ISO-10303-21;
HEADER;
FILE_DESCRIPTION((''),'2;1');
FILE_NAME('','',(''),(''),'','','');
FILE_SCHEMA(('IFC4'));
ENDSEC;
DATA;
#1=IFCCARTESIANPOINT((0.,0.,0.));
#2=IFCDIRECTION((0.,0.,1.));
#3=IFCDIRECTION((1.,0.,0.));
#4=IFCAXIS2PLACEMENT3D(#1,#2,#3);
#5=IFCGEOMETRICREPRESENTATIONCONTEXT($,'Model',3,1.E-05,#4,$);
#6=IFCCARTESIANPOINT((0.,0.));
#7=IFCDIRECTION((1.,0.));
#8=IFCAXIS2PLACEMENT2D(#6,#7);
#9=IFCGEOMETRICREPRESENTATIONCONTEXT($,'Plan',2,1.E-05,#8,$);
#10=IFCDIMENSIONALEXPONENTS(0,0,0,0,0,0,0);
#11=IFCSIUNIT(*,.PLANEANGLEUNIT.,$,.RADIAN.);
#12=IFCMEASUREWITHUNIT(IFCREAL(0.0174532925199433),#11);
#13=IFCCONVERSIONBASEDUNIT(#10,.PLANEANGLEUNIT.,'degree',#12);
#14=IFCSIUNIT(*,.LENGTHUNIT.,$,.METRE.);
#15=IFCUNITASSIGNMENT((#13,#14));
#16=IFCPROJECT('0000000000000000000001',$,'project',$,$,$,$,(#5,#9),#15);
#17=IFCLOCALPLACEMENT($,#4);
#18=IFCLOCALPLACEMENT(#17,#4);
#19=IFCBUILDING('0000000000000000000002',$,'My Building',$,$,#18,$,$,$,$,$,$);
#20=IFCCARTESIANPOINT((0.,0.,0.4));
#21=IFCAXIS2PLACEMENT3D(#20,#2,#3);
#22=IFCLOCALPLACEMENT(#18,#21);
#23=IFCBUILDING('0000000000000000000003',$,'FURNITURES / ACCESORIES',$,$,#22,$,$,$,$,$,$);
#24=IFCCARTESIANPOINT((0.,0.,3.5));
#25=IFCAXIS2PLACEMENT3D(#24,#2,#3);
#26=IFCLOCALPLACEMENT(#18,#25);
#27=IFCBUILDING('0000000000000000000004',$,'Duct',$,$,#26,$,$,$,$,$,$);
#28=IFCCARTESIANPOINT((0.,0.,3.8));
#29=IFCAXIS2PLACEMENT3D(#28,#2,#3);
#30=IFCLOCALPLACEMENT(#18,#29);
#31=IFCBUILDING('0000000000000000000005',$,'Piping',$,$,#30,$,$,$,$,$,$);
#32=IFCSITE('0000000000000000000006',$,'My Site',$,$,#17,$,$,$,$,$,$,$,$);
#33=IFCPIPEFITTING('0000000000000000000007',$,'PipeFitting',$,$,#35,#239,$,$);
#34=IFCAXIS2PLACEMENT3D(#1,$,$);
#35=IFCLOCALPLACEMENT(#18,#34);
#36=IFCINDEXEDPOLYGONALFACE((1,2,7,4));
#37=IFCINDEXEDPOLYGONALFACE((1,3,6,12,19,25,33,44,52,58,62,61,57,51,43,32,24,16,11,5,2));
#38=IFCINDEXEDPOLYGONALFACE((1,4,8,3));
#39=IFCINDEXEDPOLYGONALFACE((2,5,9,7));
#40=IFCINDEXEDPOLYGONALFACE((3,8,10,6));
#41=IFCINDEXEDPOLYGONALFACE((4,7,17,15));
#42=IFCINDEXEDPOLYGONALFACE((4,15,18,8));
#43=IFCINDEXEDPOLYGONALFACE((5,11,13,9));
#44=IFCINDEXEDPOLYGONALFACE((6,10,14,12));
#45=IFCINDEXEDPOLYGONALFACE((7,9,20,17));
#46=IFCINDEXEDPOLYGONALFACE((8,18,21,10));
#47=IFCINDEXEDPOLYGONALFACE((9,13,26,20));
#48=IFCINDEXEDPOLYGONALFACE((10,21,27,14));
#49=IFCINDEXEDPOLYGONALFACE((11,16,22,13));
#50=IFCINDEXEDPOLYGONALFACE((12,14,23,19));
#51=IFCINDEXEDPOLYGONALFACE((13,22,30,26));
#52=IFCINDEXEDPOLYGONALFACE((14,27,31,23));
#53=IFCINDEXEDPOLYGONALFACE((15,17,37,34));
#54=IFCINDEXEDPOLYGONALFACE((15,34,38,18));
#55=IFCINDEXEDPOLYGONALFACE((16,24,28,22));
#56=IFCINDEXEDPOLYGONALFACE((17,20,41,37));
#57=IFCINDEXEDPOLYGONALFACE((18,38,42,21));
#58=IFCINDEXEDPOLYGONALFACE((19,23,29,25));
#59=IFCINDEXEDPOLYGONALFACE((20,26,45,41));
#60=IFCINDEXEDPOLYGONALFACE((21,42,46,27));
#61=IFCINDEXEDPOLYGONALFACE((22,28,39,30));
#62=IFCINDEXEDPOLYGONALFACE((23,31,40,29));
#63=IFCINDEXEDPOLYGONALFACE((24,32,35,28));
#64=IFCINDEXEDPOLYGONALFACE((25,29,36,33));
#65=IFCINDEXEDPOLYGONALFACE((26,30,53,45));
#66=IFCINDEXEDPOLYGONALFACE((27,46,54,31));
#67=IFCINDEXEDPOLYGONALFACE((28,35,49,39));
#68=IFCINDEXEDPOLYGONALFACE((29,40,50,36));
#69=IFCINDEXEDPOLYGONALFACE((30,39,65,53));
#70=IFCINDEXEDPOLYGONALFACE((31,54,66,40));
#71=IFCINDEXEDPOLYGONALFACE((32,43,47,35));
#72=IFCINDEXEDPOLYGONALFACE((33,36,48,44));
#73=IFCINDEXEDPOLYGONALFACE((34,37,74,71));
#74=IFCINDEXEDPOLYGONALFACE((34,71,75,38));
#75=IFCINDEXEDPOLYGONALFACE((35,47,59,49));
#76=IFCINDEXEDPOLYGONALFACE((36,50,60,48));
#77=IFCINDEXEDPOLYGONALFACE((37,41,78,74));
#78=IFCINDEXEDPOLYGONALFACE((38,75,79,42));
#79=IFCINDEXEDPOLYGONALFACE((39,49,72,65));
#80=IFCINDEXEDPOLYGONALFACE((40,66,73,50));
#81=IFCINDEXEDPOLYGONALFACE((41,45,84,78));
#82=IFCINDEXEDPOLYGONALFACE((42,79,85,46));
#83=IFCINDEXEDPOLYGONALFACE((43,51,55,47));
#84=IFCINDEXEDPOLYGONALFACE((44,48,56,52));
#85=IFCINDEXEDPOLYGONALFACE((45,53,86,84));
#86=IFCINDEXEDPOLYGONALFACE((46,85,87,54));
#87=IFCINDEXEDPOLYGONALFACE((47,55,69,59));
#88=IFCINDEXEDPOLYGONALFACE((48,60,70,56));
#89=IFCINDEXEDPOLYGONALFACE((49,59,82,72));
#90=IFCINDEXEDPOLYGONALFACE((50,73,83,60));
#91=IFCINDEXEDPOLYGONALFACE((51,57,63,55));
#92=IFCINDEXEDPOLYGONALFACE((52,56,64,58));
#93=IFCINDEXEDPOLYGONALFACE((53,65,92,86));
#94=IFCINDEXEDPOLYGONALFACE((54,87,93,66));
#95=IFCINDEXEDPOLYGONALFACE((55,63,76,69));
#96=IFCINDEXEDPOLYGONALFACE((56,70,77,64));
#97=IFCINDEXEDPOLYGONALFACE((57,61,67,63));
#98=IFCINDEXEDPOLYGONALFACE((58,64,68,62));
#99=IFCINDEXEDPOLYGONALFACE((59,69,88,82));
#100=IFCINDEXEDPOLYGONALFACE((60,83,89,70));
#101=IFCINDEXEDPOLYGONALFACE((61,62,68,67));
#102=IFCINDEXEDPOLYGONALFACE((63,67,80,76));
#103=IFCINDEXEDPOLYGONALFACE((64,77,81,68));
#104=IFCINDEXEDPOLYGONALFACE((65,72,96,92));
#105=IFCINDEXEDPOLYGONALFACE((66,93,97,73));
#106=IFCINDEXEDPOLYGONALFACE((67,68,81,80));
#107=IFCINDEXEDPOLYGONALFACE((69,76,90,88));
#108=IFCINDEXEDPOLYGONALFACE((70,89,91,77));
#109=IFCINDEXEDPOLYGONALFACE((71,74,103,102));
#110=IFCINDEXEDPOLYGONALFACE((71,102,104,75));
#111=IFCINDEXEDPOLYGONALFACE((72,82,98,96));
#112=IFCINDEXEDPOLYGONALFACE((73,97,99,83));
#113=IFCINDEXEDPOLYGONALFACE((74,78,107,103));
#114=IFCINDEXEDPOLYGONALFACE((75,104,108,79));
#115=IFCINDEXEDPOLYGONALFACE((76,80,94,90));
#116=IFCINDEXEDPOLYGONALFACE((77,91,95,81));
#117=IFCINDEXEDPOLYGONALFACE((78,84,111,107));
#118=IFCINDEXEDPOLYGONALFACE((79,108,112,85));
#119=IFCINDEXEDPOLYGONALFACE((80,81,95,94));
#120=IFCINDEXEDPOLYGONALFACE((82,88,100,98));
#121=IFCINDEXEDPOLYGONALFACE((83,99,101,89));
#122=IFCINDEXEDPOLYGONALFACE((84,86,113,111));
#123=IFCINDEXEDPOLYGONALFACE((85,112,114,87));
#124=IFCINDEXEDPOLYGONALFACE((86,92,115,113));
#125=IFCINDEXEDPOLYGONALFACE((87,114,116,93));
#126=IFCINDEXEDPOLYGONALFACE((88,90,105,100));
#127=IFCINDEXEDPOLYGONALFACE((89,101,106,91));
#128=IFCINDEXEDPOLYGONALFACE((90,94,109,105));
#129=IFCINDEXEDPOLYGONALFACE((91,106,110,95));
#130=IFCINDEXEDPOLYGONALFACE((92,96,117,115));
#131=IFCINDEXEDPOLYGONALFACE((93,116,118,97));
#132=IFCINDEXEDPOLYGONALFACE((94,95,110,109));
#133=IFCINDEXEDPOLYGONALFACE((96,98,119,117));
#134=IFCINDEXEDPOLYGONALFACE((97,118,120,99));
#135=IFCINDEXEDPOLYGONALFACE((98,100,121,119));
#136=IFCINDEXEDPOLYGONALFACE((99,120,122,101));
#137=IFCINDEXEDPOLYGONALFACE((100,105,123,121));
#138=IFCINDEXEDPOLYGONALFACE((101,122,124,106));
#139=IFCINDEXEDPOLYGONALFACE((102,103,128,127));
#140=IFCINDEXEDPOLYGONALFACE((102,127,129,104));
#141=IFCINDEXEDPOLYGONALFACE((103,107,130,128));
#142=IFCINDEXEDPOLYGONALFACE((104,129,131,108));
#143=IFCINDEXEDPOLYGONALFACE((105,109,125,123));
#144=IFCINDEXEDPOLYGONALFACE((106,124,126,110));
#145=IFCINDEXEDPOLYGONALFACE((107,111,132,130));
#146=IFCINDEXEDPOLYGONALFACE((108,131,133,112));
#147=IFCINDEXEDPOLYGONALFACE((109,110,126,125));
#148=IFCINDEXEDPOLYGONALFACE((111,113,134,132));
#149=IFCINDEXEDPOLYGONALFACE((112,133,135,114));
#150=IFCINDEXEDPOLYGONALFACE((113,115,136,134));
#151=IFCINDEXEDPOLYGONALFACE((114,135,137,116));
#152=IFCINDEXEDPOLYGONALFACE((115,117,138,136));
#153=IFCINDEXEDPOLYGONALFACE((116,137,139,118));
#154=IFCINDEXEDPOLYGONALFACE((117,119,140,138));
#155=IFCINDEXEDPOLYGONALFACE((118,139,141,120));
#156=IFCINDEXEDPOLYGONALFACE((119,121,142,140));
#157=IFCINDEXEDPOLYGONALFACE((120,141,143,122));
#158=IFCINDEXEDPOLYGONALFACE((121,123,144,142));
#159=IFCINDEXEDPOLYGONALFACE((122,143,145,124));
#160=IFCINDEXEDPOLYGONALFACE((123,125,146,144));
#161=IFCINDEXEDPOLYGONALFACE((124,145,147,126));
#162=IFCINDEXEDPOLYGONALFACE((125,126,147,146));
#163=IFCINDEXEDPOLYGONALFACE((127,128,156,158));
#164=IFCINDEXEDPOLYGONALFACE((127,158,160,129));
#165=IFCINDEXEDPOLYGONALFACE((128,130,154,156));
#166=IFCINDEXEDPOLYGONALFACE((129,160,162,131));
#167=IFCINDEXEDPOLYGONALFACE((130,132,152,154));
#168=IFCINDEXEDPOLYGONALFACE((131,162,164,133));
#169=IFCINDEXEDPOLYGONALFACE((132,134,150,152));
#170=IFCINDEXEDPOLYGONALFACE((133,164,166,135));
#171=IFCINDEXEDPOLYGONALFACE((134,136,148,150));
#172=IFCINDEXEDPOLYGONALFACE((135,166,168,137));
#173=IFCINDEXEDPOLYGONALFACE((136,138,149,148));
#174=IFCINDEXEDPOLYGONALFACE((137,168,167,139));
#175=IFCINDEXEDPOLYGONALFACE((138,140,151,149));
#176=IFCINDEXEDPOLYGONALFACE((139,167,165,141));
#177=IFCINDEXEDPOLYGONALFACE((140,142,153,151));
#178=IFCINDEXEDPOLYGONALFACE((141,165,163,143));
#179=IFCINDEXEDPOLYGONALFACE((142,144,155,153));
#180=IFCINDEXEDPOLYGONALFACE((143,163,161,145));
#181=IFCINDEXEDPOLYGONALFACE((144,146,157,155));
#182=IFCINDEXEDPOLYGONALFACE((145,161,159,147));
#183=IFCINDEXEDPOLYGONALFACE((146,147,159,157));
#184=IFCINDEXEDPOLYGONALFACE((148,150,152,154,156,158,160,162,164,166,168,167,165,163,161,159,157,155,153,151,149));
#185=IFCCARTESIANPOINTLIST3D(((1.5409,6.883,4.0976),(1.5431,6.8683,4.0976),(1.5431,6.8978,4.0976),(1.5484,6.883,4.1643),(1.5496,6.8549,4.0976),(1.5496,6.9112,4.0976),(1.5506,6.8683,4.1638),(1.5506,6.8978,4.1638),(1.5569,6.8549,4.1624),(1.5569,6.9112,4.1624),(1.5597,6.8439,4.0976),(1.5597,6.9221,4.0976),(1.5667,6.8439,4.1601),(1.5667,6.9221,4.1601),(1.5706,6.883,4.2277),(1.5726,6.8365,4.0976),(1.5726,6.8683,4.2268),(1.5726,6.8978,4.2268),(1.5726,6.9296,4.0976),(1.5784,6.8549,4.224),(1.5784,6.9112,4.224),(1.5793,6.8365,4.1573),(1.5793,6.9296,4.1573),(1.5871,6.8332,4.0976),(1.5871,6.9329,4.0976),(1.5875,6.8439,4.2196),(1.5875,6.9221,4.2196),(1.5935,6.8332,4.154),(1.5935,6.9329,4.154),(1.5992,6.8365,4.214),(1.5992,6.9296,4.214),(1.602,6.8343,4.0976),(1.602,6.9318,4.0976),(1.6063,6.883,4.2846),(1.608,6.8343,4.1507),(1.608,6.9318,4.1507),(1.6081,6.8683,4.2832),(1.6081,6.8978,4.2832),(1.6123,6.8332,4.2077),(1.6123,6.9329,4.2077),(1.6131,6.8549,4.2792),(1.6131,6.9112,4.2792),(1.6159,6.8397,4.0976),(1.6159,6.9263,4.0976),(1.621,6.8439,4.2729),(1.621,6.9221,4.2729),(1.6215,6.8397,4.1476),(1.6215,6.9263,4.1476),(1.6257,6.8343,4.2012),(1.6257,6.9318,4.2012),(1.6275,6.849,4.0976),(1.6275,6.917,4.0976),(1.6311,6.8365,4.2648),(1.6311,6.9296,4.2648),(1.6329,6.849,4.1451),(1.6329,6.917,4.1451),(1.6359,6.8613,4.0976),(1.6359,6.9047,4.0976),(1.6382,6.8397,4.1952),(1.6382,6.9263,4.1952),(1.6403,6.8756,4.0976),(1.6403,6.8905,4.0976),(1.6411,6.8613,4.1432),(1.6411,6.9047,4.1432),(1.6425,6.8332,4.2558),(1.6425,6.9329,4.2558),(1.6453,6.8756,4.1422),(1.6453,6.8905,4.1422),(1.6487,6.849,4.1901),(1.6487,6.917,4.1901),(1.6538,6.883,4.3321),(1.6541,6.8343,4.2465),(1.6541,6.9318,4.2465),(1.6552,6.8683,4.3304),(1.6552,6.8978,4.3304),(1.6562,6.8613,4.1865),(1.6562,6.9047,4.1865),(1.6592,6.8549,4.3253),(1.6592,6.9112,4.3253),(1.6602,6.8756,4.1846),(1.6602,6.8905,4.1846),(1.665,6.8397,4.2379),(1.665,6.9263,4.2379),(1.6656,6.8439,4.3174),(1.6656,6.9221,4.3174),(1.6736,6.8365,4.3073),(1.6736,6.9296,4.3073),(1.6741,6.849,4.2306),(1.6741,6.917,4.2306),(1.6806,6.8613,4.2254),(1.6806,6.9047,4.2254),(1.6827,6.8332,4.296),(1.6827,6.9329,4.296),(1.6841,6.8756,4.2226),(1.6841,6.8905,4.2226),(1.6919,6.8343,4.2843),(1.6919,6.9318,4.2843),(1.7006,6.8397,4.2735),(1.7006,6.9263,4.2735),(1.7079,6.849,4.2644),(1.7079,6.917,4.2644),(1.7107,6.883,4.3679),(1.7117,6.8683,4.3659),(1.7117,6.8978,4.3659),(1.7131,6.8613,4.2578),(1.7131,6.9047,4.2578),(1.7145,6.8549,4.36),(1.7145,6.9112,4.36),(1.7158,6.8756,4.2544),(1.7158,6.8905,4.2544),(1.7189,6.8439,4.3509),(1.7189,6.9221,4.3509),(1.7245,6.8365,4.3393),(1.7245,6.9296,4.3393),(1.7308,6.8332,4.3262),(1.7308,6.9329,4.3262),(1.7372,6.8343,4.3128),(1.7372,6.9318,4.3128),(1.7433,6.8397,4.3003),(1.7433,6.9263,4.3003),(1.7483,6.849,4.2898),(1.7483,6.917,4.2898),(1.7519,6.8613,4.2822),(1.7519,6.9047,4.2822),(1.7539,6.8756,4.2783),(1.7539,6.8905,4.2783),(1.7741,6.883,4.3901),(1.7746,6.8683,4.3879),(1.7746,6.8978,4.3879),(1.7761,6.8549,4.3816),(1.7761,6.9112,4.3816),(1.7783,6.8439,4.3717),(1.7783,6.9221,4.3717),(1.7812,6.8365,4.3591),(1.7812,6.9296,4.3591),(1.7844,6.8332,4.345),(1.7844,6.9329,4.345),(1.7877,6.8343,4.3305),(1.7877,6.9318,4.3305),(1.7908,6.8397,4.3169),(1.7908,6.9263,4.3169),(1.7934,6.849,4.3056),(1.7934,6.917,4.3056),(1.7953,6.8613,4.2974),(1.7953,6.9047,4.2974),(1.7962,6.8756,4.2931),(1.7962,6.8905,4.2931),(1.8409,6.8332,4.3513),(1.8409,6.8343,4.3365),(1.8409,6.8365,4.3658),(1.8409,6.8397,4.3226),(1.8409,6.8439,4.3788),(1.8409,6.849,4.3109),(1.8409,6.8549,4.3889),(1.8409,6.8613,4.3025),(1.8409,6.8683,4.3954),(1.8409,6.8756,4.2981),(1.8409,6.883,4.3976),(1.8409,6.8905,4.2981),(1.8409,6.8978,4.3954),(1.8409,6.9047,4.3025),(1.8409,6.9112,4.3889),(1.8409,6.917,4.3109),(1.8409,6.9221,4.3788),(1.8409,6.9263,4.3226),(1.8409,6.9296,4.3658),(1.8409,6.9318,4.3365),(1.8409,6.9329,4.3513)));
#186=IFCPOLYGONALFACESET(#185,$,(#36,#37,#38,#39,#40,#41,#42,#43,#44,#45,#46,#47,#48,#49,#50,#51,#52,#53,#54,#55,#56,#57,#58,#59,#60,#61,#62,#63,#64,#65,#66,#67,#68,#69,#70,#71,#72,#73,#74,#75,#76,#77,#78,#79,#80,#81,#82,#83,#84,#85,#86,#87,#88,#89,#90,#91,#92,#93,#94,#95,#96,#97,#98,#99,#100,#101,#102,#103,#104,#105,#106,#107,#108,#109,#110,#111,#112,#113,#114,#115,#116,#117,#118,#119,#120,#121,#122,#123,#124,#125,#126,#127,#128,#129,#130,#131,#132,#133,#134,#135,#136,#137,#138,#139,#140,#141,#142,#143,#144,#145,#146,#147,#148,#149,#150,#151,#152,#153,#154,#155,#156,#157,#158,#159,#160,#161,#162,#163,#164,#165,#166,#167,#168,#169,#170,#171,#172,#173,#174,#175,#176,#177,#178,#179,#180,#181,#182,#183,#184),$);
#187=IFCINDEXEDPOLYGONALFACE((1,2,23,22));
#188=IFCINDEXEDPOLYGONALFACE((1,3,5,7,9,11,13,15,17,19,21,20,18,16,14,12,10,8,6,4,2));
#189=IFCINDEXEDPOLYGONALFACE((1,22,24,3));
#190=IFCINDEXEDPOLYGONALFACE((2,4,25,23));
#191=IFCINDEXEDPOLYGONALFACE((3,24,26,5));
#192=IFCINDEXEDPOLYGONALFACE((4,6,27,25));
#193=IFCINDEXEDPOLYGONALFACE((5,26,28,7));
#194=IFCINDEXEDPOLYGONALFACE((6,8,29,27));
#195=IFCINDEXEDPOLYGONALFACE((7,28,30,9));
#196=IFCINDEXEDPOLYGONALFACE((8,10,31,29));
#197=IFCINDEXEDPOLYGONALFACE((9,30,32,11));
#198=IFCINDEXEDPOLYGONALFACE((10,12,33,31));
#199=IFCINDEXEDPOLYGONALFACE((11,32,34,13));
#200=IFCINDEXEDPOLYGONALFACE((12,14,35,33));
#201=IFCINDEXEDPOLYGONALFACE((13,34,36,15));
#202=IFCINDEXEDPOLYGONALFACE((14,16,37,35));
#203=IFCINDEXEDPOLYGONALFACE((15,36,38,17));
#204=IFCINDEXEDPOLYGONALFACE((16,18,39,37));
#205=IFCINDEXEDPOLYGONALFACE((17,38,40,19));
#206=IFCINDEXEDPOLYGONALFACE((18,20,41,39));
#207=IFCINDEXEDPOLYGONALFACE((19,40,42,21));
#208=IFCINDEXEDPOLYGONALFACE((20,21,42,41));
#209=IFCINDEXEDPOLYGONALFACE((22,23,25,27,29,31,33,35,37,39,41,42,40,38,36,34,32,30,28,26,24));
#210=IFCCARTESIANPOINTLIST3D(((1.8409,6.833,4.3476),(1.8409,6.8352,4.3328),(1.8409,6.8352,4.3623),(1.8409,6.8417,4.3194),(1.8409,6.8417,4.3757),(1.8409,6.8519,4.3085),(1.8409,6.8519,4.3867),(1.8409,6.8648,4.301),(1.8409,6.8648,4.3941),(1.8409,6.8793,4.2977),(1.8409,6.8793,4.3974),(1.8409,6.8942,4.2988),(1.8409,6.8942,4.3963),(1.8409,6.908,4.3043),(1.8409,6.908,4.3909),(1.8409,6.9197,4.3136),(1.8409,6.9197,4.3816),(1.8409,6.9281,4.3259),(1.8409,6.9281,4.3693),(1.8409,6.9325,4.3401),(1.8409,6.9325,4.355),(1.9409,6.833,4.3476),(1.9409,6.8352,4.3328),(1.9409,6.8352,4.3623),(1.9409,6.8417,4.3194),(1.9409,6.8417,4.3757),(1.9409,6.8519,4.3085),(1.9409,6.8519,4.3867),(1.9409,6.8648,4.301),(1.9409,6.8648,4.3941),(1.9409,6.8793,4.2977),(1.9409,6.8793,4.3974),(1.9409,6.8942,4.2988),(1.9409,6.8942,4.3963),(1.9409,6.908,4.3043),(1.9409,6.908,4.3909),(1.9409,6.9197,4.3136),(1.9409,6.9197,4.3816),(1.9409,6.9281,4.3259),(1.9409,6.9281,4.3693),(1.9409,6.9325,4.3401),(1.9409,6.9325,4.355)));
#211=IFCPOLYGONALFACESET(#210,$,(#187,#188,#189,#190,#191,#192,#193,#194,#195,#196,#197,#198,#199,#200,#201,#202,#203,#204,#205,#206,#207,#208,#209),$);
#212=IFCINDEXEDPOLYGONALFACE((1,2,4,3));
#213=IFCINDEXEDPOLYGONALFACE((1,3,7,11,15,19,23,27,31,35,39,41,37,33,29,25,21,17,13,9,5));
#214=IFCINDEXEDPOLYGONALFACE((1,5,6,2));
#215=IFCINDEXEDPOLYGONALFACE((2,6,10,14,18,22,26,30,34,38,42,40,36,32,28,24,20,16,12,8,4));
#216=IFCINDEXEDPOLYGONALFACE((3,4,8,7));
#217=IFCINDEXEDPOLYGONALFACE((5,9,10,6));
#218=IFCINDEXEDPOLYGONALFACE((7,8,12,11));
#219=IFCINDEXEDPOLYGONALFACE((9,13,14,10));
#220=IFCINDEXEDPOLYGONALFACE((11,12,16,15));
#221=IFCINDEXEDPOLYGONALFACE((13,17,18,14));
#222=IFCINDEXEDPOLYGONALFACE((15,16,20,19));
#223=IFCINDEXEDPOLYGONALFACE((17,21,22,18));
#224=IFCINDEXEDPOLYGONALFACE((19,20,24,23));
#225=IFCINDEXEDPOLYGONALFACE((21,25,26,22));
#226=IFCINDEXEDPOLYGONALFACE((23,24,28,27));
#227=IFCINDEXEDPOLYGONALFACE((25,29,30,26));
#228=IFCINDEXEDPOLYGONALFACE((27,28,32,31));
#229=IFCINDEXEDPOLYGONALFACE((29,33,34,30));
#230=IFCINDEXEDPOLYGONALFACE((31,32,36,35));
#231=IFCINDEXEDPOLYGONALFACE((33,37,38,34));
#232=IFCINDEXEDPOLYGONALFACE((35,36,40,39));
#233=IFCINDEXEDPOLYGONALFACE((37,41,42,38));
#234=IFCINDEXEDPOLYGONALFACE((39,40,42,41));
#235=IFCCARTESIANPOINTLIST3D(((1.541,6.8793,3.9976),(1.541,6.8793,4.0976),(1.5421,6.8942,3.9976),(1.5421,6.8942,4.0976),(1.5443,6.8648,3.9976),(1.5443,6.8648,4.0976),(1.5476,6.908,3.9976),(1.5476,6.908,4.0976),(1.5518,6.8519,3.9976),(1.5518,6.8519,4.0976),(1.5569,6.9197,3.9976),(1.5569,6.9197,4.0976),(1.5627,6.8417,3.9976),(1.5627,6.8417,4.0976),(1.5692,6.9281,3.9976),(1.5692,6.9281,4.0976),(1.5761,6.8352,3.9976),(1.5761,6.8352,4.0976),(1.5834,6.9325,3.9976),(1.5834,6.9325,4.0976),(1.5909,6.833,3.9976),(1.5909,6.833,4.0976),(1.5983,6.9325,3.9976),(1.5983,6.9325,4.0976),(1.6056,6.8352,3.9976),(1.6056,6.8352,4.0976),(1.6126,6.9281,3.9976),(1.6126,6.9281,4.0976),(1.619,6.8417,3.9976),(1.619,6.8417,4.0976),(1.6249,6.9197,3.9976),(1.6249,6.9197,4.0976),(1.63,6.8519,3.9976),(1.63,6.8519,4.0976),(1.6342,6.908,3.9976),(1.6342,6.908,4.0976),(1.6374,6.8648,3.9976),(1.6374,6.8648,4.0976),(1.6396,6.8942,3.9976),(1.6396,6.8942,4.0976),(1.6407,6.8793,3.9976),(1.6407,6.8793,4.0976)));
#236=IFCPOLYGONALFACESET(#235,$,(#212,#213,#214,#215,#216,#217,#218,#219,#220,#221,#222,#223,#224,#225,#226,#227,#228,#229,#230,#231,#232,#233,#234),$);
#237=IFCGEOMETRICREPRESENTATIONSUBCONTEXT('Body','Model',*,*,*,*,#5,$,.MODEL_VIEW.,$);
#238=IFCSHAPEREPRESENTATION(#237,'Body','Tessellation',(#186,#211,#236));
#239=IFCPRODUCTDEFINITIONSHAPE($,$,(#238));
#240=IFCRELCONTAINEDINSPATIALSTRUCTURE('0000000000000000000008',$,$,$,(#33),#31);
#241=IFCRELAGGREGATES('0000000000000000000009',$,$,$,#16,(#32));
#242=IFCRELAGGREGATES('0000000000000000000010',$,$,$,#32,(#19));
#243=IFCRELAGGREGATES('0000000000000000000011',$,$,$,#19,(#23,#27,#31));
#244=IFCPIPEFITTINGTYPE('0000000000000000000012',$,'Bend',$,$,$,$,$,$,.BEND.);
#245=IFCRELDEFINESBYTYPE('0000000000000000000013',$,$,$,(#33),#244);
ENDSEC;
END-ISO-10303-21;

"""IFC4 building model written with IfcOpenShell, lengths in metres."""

from ifc_helpers import new_model, entity, si_unit, converted_unit, frame, origin_with_axes, origin_2d_with_axis, place, context, subcontext, project, spatial, circle, extrude, source, transform, mapped, type_object, type_shapes, element, save


model = new_model("IFC4")

# Units and contexts
model_context = context("Model", 3, precision=1e-05, world=origin_with_axes())
plan_context = context("Plan", 2, precision=1e-05, world=origin_2d_with_axis())
body_context = subcontext(model_context, "Body", "Model", "MODEL_VIEW")
ifc_project = project(units=[converted_unit("PLANEANGLEUNIT", "degree", entity("IfcReal", 0.0174532925199433), si_unit("PLANEANGLEUNIT", "RADIAN"), dimensions=[0, 0, 0, 0, 0, 0, 0]), si_unit("LENGTHUNIT", "METRE")], contexts=[model_context, plan_context])

# Site, building
site_placement = place(None, origin_with_axes())
site = spatial("IfcSite", under=ifc_project, at=site_placement, Name="My Site")
building_1_placement = place(site_placement, origin_with_axes())
building_1 = spatial("IfcBuilding", under=site, at=building_1_placement, Name="My Building")

# Shared definitions
building_2_placement = place(building_1_placement, frame((0.0, 0.0, 0.4), z_axis=(0.0, 0.0, 1.0), x_axis=(1.0, 0.0, 0.0)))
building_2 = spatial("IfcBuilding", under=building_1, at=building_2_placement, Name="FURNITURES / ACCESORIES")

# Shared definitions
building_3_placement = place(building_1_placement, frame((0.0, 0.0, 3.5), z_axis=(0.0, 0.0, 1.0), x_axis=(1.0, 0.0, 0.0)))
building_3 = spatial("IfcBuilding", under=building_1, at=building_3_placement, Name="Duct")

# Shared definitions
building_4_placement = place(building_1_placement, frame((0.0, 0.0, 3.8), z_axis=(0.0, 0.0, 1.0), x_axis=(1.0, 0.0, 0.0)))
building_4 = spatial("IfcBuilding", under=building_1, at=building_4_placement, Name="Piping")

# Pipe fitting
pipe_fitting_type_1 = type_object("IfcPipeFittingType", Name="Bend", PredefinedType="BEND")
shared_shape = source(origin_with_axes(), body_context, "Body", "SolidModel", [
    entity("IfcSweptDiskSolid", entity("IfcIndexedPolyCurve", entity("IfcCartesianPointList3D", [[0.0, 0.0, 0.1], [0.0, -0.0732, 0.2768], [0.0, -0.25, 0.35]]), [entity("IfcArcIndex", [1, 2, 3])]), 0.05),
    extrude(circle(Radius=0.05), origin_with_axes(), (0.0, 0.0, 1.0), 0.1),
    extrude(circle(Radius=0.05), frame((0.0, -0.25, 0.35), z_axis=(0.0, -1.0, -0.000001), x_axis=(1.0, 0.0, 0.0)), (0.0, 0.0, 1.0), 0.1),
])
type_shapes(pipe_fitting_type_1, [shared_shape])
for number, where, z_axis, x_axis, name in (
    (1, (1.9409, 6.883, 0.5476), (-1.0, 0.000001, -0.000001), (-0.000001, -1.0, 0.0), "PipeFitting"),
):
    element("IfcPipeFitting", number, at=place(building_4_placement, frame(where, z_axis=z_axis, x_axis=x_axis)), inside=building_4, type_object=pipe_fitting_type_1, Name=name, context=body_context, shape_type="MappedRepresentation", body=[
        mapped(shared_shape, transform((0.0, 0.0, 0.0), x_axis=(1.0, 0.0, 0.0), y_axis=(0.0, 1.0, 0.0), z_axis=(0.0, 0.0, 1.0), scale=1.0)),
    ])

save(model, "model.ifc")
